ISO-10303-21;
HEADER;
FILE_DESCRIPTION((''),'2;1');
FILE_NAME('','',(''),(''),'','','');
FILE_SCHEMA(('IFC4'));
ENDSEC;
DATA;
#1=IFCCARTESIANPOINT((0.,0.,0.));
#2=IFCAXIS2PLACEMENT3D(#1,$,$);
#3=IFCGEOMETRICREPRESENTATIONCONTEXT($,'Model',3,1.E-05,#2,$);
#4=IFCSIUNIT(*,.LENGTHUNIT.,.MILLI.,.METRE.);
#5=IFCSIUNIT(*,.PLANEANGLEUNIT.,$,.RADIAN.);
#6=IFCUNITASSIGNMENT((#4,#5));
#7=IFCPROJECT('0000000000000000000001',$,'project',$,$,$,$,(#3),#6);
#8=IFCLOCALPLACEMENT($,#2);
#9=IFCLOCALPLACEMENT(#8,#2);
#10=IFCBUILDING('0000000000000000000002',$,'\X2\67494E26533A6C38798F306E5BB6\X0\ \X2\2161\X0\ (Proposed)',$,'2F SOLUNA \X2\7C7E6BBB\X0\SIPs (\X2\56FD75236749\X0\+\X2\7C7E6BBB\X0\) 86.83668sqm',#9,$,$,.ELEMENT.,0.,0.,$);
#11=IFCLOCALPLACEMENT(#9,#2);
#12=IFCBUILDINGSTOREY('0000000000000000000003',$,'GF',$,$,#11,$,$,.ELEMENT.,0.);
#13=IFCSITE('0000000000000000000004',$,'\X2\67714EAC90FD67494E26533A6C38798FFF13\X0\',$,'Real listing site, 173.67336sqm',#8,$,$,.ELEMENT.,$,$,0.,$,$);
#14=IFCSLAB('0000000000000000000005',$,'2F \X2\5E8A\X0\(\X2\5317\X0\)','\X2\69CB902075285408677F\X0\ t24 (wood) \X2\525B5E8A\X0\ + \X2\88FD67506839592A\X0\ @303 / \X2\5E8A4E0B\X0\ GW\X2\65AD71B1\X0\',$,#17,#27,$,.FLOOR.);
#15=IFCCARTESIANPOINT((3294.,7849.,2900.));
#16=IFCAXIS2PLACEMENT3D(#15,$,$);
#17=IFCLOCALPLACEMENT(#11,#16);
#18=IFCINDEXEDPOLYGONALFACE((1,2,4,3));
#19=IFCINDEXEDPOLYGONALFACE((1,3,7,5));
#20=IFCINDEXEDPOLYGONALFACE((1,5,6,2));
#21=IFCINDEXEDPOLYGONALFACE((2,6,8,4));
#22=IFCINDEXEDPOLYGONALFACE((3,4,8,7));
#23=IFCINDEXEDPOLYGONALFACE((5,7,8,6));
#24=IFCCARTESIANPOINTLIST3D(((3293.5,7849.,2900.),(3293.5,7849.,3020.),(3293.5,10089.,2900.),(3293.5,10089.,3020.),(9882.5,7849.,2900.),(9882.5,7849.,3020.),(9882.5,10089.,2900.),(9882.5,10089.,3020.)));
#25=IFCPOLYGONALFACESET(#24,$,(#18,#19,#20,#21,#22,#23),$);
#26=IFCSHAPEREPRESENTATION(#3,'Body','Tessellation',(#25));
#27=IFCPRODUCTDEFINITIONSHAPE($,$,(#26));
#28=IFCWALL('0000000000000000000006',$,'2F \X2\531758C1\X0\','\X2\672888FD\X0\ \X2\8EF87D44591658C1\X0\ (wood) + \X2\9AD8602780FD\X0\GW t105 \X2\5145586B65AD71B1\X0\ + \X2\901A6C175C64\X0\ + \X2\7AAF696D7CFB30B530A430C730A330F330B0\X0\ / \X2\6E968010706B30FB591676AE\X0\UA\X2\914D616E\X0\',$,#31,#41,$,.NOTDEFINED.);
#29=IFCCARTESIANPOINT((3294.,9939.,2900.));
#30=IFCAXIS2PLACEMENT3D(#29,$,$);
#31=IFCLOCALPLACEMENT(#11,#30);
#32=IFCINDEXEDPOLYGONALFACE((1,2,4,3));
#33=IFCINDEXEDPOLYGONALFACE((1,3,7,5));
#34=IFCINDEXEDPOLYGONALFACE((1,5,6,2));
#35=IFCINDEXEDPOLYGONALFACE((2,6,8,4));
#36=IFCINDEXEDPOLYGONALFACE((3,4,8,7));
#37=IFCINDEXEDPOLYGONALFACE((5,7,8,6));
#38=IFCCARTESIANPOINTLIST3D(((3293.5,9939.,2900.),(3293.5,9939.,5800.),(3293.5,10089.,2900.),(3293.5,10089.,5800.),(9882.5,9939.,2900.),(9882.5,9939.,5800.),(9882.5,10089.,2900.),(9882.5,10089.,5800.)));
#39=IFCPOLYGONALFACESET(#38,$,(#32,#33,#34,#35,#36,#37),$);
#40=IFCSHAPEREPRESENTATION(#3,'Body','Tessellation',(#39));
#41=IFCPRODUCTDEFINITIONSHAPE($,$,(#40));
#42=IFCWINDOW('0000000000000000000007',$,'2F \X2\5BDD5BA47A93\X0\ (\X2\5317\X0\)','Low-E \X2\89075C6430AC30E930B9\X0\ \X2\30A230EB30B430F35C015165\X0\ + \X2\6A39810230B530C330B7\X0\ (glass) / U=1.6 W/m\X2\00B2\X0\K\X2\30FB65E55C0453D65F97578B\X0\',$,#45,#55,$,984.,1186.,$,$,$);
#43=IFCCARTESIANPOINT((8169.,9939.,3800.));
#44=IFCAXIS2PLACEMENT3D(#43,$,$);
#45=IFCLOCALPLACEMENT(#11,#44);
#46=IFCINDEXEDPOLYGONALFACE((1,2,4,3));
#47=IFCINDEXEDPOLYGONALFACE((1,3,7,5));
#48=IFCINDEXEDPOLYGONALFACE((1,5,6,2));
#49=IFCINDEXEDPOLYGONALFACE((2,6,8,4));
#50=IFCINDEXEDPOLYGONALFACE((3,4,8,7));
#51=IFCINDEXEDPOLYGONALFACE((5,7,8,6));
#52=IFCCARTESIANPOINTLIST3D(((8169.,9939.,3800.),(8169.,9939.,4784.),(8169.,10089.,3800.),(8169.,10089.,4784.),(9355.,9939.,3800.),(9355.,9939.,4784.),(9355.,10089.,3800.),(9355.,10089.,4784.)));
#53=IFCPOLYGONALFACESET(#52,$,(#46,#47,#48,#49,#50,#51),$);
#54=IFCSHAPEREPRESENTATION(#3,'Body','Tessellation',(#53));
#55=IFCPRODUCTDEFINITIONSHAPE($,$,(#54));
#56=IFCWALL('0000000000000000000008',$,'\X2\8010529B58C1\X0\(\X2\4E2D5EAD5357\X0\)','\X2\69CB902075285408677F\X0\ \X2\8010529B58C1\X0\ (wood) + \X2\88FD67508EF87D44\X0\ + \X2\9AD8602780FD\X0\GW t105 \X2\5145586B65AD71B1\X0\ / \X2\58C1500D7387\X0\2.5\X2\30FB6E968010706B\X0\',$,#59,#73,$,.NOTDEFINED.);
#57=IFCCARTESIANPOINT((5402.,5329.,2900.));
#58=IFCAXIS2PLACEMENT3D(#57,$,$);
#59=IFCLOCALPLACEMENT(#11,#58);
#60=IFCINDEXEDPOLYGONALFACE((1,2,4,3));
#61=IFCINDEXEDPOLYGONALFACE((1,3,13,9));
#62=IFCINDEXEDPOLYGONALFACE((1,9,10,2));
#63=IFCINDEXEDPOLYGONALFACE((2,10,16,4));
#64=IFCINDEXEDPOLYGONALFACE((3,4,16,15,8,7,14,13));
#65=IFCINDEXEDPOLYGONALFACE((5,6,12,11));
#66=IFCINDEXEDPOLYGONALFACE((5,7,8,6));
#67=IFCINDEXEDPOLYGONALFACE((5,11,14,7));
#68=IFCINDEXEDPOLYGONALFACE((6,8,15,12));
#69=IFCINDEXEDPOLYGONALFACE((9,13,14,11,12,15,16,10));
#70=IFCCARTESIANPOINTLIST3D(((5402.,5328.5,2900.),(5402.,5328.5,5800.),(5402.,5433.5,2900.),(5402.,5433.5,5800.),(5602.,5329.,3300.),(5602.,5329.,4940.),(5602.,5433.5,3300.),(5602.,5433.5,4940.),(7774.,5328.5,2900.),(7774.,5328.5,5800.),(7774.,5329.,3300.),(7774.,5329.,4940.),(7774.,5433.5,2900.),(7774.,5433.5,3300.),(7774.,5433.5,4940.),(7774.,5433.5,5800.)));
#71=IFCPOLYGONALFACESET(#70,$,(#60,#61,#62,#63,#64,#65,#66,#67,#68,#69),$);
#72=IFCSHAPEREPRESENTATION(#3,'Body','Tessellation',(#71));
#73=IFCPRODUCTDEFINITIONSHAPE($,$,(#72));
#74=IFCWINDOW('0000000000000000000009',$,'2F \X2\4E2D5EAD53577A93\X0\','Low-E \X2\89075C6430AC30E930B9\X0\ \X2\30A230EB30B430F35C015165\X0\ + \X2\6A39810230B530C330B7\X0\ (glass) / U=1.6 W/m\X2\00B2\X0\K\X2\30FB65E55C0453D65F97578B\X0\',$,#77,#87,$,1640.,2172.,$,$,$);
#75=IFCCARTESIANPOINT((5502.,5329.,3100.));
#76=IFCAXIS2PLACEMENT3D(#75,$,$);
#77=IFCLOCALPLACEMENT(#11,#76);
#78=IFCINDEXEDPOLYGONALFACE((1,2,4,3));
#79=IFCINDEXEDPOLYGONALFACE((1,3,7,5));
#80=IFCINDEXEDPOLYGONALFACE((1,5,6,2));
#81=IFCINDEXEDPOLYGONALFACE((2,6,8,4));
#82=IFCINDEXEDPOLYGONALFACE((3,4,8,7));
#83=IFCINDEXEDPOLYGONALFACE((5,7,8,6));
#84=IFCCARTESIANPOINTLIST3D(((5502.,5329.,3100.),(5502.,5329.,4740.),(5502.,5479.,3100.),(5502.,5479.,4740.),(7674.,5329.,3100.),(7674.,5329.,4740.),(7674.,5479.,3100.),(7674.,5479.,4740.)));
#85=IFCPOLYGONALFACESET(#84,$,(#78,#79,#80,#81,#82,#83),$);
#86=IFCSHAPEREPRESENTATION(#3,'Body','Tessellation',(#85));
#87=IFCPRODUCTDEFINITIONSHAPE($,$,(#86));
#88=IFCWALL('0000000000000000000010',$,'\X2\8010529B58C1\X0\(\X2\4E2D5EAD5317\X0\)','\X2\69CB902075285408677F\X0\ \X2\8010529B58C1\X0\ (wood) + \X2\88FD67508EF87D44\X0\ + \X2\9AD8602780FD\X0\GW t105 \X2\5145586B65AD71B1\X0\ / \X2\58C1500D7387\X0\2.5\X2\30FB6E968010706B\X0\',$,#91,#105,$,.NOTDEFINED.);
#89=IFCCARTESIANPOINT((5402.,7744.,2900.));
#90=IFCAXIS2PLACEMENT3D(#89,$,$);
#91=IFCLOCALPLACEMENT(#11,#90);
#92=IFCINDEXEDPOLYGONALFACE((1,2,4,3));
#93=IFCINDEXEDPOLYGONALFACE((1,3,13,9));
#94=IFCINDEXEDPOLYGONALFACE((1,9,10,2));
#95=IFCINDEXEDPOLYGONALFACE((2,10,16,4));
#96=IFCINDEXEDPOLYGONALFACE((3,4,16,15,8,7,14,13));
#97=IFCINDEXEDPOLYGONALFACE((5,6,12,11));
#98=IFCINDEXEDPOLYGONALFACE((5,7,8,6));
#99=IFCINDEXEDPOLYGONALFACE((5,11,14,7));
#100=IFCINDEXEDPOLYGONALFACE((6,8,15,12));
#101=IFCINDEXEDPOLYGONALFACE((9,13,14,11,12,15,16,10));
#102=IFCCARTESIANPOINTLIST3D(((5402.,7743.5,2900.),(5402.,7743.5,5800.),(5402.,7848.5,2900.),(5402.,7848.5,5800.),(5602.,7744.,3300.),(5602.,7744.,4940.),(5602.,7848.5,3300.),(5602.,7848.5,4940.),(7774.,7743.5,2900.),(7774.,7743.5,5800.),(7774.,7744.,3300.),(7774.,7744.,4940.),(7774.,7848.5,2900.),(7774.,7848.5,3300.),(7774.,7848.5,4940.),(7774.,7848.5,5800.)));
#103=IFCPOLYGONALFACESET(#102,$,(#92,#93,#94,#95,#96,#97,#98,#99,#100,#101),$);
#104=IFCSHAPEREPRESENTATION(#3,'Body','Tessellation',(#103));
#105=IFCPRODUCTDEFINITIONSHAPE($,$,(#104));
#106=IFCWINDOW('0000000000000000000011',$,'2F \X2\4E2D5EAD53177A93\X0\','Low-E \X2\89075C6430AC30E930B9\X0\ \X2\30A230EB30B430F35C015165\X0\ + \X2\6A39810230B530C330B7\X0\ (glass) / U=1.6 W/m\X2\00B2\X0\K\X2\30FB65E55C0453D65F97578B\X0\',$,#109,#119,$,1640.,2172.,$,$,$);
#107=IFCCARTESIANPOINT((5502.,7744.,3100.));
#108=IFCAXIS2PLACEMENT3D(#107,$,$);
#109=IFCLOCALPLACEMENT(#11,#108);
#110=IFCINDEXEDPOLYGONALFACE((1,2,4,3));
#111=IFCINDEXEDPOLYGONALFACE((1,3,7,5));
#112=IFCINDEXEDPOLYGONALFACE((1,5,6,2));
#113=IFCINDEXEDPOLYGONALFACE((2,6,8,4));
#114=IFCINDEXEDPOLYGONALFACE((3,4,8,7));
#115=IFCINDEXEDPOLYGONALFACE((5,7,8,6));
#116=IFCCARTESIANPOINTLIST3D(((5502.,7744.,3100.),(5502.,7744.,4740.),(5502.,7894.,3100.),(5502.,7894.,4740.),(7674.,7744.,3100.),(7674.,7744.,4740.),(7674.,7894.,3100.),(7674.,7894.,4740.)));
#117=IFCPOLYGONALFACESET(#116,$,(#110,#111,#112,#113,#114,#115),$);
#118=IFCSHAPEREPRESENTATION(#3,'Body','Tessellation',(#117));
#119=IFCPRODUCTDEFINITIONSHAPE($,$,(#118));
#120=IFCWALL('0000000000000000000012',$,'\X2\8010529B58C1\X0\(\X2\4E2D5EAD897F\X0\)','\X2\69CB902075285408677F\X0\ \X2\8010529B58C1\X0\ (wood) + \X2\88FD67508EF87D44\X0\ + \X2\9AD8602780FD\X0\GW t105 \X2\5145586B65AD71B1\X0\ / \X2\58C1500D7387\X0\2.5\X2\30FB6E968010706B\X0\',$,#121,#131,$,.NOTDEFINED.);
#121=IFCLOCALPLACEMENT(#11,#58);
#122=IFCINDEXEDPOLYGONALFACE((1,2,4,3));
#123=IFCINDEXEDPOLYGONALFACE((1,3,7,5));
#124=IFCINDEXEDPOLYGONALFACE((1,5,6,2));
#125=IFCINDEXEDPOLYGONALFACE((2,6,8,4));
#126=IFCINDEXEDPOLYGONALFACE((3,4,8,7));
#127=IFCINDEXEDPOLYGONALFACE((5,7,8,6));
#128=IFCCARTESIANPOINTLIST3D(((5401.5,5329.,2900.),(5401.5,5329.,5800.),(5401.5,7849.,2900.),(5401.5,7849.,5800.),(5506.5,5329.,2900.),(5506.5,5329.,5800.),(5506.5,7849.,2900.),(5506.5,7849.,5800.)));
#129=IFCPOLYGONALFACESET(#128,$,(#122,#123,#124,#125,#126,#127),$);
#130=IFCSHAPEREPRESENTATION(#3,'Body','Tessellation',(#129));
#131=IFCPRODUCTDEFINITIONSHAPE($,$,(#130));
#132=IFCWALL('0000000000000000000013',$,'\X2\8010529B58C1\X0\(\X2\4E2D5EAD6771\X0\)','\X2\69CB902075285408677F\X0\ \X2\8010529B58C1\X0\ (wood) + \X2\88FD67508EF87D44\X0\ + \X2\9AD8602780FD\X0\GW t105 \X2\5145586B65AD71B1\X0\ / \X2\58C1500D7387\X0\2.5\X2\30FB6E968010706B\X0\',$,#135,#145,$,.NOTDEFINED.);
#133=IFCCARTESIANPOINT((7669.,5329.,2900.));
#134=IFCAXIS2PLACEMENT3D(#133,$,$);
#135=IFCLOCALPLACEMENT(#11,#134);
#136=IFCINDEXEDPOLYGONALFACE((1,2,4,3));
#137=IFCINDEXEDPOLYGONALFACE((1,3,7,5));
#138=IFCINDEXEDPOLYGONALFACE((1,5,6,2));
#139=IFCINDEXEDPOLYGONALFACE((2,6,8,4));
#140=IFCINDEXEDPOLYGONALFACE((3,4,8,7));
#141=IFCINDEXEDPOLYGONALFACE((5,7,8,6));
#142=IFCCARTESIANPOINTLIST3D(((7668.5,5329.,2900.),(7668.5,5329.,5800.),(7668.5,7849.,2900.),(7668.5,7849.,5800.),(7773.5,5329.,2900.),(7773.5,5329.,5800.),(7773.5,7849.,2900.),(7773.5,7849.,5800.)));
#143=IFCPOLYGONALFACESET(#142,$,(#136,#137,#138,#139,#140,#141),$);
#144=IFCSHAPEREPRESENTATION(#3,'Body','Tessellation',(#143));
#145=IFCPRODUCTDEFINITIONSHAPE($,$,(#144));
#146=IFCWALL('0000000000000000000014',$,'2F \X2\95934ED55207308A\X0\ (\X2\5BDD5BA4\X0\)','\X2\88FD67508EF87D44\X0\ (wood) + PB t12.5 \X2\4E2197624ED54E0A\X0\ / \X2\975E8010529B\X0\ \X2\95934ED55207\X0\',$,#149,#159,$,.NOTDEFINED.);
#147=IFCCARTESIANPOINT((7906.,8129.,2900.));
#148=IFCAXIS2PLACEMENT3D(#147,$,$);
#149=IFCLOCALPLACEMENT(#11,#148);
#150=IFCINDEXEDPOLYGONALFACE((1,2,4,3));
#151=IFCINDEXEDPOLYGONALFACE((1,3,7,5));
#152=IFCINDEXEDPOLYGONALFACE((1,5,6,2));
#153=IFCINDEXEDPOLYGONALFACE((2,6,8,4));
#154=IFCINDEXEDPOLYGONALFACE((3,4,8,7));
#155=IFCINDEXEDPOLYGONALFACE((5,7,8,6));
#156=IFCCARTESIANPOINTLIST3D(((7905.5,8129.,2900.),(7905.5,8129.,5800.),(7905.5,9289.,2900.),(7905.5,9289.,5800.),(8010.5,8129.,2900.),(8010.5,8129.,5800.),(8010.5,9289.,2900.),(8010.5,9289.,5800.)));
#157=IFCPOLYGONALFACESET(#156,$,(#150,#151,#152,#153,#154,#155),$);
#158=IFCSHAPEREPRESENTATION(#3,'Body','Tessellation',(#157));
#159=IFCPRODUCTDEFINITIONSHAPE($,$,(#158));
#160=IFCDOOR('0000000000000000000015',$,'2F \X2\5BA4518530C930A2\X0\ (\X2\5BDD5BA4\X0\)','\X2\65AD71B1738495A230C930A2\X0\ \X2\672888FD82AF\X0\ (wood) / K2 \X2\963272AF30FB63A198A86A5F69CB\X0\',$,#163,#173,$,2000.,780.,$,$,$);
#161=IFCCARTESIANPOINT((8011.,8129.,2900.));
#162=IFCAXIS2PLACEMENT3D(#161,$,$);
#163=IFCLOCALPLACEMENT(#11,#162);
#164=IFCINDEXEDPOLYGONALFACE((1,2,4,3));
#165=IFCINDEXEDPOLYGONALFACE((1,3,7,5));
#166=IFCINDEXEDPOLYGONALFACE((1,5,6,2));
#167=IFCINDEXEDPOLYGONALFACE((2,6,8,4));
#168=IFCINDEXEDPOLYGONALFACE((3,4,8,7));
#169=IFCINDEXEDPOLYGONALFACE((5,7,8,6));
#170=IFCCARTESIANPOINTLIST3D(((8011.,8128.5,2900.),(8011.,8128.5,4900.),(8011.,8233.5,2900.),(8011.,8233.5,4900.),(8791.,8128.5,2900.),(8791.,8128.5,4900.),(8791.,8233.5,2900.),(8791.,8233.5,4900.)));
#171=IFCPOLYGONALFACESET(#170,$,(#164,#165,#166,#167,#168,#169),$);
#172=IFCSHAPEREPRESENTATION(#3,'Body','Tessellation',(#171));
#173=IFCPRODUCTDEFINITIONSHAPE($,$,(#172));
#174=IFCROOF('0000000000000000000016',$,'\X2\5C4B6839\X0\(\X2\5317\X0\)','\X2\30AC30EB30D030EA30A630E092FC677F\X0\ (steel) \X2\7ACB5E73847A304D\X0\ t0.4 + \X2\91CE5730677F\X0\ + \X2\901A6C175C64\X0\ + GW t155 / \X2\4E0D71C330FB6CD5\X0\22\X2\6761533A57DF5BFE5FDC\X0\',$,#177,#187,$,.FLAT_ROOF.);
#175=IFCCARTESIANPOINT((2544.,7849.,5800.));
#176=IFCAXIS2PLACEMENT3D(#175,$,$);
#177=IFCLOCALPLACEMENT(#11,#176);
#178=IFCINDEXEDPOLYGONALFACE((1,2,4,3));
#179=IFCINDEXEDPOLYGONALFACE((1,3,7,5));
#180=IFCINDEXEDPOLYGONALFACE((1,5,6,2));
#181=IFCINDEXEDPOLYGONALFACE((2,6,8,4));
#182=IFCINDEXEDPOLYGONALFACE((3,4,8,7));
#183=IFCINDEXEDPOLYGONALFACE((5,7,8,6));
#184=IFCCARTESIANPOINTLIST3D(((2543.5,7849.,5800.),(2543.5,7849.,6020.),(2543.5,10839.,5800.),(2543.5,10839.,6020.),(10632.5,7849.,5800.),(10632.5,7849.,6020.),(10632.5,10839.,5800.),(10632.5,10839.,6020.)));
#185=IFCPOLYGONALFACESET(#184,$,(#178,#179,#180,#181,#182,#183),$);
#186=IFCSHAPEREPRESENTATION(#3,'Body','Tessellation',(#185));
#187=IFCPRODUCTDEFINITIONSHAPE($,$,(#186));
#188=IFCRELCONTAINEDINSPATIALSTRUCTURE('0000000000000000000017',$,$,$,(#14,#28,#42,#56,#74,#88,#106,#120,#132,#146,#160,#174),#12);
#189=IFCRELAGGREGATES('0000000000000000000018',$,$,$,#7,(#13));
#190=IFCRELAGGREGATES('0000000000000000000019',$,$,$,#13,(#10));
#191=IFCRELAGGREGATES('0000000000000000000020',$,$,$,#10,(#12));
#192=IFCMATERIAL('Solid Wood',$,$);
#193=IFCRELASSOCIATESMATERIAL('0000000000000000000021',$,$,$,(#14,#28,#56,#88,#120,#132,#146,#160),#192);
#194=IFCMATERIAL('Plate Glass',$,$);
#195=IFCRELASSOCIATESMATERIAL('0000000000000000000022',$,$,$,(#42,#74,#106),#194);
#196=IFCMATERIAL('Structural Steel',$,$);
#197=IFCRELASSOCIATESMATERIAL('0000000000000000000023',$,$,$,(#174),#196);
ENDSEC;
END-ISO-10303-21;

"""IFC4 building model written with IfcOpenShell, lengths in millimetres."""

from ifc_helpers import new_model, si_unit, frame, frame_2d, origin, place, context, project, spatial, rectangle, extrude, material, element, fill, save


model = new_model("IFC4")

# Units and contexts
model_context = context("Model", 3, precision=1e-05, world=origin())
ifc_project = project(units=[si_unit("LENGTHUNIT", "METRE", prefix="MILLI"), si_unit("PLANEANGLEUNIT", "RADIAN")], contexts=[model_context])

# Site, building, storey
site_placement = place(None, origin())
site = spatial("IfcSite", under=ifc_project, at=site_placement, Name="東京都杉並区永福３", ObjectType="Real listing site, 173.67336sqm", CompositionType="ELEMENT", RefElevation=0.0)
building_placement = place(site_placement, origin())
building = spatial("IfcBuilding", under=site, at=building_placement, Name="杉並区永福の家 Ⅱ (Proposed)", ObjectType="2F SOLUNA 籾殻SIPs (国産杉+籾殻) 86.83668sqm", CompositionType="ELEMENT", ElevationOfRefHeight=0.0, ElevationOfTerrain=0.0)
storey_placement = place(building_placement, origin())
storey = spatial("IfcBuildingStorey", under=building, at=storey_placement, Name="GF", CompositionType="ELEMENT", Elevation=0.0)

# Slab
ifc_material_1 = material(Name="Solid Wood")
slab_placement = place(storey_placement, frame((3294.0, 7849.0, 2900.0)))
element("IfcSlab", 1, at=slab_placement, inside=storey, material=ifc_material_1, Name="2F 床(北)", Description="構造用合板 t24 (wood) 剛床 + 製材根太 @303 / 床下 GW断熱", PredefinedType="FLOOR", context=model_context, shape_type="SweptSolid", body=[
    extrude(rectangle(XDim=6589.0, YDim=2240.0, at=frame_2d((3294.0, 1120.0))), frame((3294.0, 7849.0, 2900.0)), (0.0, 0.0, 1.0), 120.0),
])

# Walls, openings, windows
wall_1_placement = place(storey_placement, frame((3294.0, 9939.0, 2900.0)))
wall_1 = element("IfcWall", 2, at=wall_1_placement, inside=storey, material=ifc_material_1, Name="2F 北壁", Description="木製 軸組外壁 (wood) + 高性能GW t105 充填断熱 + 通気層 + 窯業系サイディング / 準耐火・外皮UA配慮", PredefinedType="NOTDEFINED", context=model_context, shape_type="SweptSolid", body=[
    extrude(rectangle(XDim=6589.0, YDim=150.0, at=frame_2d((3294.0, 75.0))), frame((3294.0, 9939.0, 2900.0)), (0.0, 0.0, 1.0), 2900.0),
])
opening_1_placement = place(storey_placement, frame((8169.0, 9939.0, 3800.0)))
opening_1 = element("IfcOpeningElement", 3, at=opening_1_placement, cuts=wall_1, PredefinedType="NOTDEFINED", context=model_context, shape_type="SweptSolid", body=[
    extrude(rectangle(XDim=1186.0, YDim=150.0, at=frame_2d((593.0, 75.0))), frame((8169.0, 9939.0, 3800.0)), (0.0, 0.0, 1.0), 984.0),
])
ifc_material_2 = material(Name="Plate Glass")
window_1_placement = place(storey_placement, frame((8169.0, 9939.0, 3800.0)))
window_1 = element("IfcWindow", 4, at=window_1_placement, inside=storey, material=ifc_material_2, Name="2F 寝室窓 (北)", Description="Low-E 複層ガラス アルゴン封入 + 樹脂サッシ (glass) / U=1.6 W/m²K・日射取得型", OverallHeight=984.0, OverallWidth=1186.0, context=model_context, shape_type="SweptSolid", body=[
    extrude(rectangle(XDim=1186.0, YDim=150.0, at=frame_2d((593.0, 75.0))), frame((8169.0, 9939.0, 3800.0)), (0.0, 0.0, 1.0), 984.0),
])
fill(opening_1, window_1)
wall_2_placement = place(storey_placement, frame((5402.0, 5329.0, 2900.0)))
wall_2 = element("IfcWall", 5, at=wall_2_placement, inside=storey, material=ifc_material_1, Name="耐力壁(中庭南)", Description="構造用合板 耐力壁 (wood) + 製材軸組 + 高性能GW t105 充填断熱 / 壁倍率2.5・準耐火", PredefinedType="NOTDEFINED", context=model_context, shape_type="SweptSolid", body=[
    extrude(rectangle(XDim=2372.0, YDim=105.0, at=frame_2d((1186.0, 52.0))), frame((5402.0, 5329.0, 2900.0)), (0.0, 0.0, 1.0), 2900.0),
])
opening_2_placement = place(storey_placement, frame((5502.0, 5329.0, 3100.0)))
opening_2 = element("IfcOpeningElement", 6, at=opening_2_placement, cuts=wall_2, PredefinedType="NOTDEFINED", context=model_context, shape_type="SweptSolid", body=[
    extrude(rectangle(XDim=2172.0, YDim=150.0, at=frame_2d((1086.0, 75.0))), frame((5502.0, 5329.0, 3100.0)), (0.0, 0.0, 1.0), 1640.0),
])
window_2_placement = place(storey_placement, frame((5502.0, 5329.0, 3100.0)))
window_2 = element("IfcWindow", 7, at=window_2_placement, inside=storey, material=ifc_material_2, Name="2F 中庭南窓", Description="Low-E 複層ガラス アルゴン封入 + 樹脂サッシ (glass) / U=1.6 W/m²K・日射取得型", OverallHeight=1640.0, OverallWidth=2172.0, context=model_context, shape_type="SweptSolid", body=[
    extrude(rectangle(XDim=2172.0, YDim=150.0, at=frame_2d((1086.0, 75.0))), frame((5502.0, 5329.0, 3100.0)), (0.0, 0.0, 1.0), 1640.0),
])
fill(opening_2, window_2)
wall_3_placement = place(storey_placement, frame((5402.0, 7744.0, 2900.0)))
wall_3 = element("IfcWall", 8, at=wall_3_placement, inside=storey, material=ifc_material_1, Name="耐力壁(中庭北)", Description="構造用合板 耐力壁 (wood) + 製材軸組 + 高性能GW t105 充填断熱 / 壁倍率2.5・準耐火", PredefinedType="NOTDEFINED", context=model_context, shape_type="SweptSolid", body=[
    extrude(rectangle(XDim=2372.0, YDim=105.0, at=frame_2d((1186.0, 52.0))), frame((5402.0, 7744.0, 2900.0)), (0.0, 0.0, 1.0), 2900.0),
])
opening_3_placement = place(storey_placement, frame((5502.0, 7744.0, 3100.0)))
opening_3 = element("IfcOpeningElement", 9, at=opening_3_placement, cuts=wall_3, PredefinedType="NOTDEFINED", context=model_context, shape_type="SweptSolid", body=[
    extrude(rectangle(XDim=2172.0, YDim=150.0, at=frame_2d((1086.0, 75.0))), frame((5502.0, 7744.0, 3100.0)), (0.0, 0.0, 1.0), 1640.0),
])
window_3_placement = place(storey_placement, frame((5502.0, 7744.0, 3100.0)))
window_3 = element("IfcWindow", 10, at=window_3_placement, inside=storey, material=ifc_material_2, Name="2F 中庭北窓", Description="Low-E 複層ガラス アルゴン封入 + 樹脂サッシ (glass) / U=1.6 W/m²K・日射取得型", OverallHeight=1640.0, OverallWidth=2172.0, context=model_context, shape_type="SweptSolid", body=[
    extrude(rectangle(XDim=2172.0, YDim=150.0, at=frame_2d((1086.0, 75.0))), frame((5502.0, 7744.0, 3100.0)), (0.0, 0.0, 1.0), 1640.0),
])
fill(opening_3, window_3)

# Walls
wall_4_placement = place(storey_placement, frame((5402.0, 5329.0, 2900.0)))
element("IfcWall", 11, at=wall_4_placement, inside=storey, material=ifc_material_1, Name="耐力壁(中庭西)", Description="構造用合板 耐力壁 (wood) + 製材軸組 + 高性能GW t105 充填断熱 / 壁倍率2.5・準耐火", PredefinedType="NOTDEFINED", context=model_context, shape_type="SweptSolid", body=[
    extrude(rectangle(XDim=105.0, YDim=2520.0, at=frame_2d((52.0, 1260.0))), frame((5402.0, 5329.0, 2900.0)), (0.0, 0.0, 1.0), 2900.0),
])
wall_5_placement = place(storey_placement, frame((7669.0, 5329.0, 2900.0)))
element("IfcWall", 12, at=wall_5_placement, inside=storey, material=ifc_material_1, Name="耐力壁(中庭東)", Description="構造用合板 耐力壁 (wood) + 製材軸組 + 高性能GW t105 充填断熱 / 壁倍率2.5・準耐火", PredefinedType="NOTDEFINED", context=model_context, shape_type="SweptSolid", body=[
    extrude(rectangle(XDim=105.0, YDim=2520.0, at=frame_2d((52.0, 1260.0))), frame((7669.0, 5329.0, 2900.0)), (0.0, 0.0, 1.0), 2900.0),
])
wall_6_placement = place(storey_placement, frame((7906.0, 8129.0, 2900.0)))
element("IfcWall", 13, at=wall_6_placement, inside=storey, material=ifc_material_1, Name="2F 間仕切り (寝室)", Description="製材軸組 (wood) + PB t12.5 両面仕上 / 非耐力 間仕切", PredefinedType="NOTDEFINED", context=model_context, shape_type="SweptSolid", body=[
    extrude(rectangle(XDim=105.0, YDim=1160.0, at=frame_2d((52.0, 580.0))), frame((7906.0, 8129.0, 2900.0)), (0.0, 0.0, 1.0), 2900.0),
])

# Door
door_placement = place(storey_placement, frame((8011.0, 8129.0, 2900.0)))
element("IfcDoor", 14, at=door_placement, inside=storey, material=ifc_material_1, Name="2F 室内ドア (寝室)", Description="断熱玄関ドア 木製芯 (wood) / K2 防犯・採風機構", OverallHeight=2000.0, OverallWidth=780.0, context=model_context, shape_type="SweptSolid", body=[
    extrude(rectangle(XDim=780.0, YDim=105.0, at=frame_2d((390.0, 52.0))), frame((8011.0, 8129.0, 2900.0)), (0.0, 0.0, 1.0), 2000.0),
])

# Roof
ifc_material_3 = material(Name="Structural Steel")
for number, where, name in (
    (15, (2544.0, 7849.0, 5800.0), "屋根(北)"),
):
    element("IfcRoof", number, at=place(storey_placement, frame(where)), inside=storey, material=ifc_material_3, Name=name, Description="ガルバリウム鋼板 (steel) 立平葺き t0.4 + 野地板 + 通気層 + GW t155 / 不燃・法22条区域対応", PredefinedType="FLAT_ROOF", context=model_context, shape_type="SweptSolid", body=[
        extrude(rectangle(XDim=8089.0, YDim=2990.0, at=frame_2d((4044.0, 1495.0))), frame((2544.0, 7849.0, 5800.0)), (0.0, 0.0, 1.0), 220.0),
    ])

save(model, "model.ifc")
